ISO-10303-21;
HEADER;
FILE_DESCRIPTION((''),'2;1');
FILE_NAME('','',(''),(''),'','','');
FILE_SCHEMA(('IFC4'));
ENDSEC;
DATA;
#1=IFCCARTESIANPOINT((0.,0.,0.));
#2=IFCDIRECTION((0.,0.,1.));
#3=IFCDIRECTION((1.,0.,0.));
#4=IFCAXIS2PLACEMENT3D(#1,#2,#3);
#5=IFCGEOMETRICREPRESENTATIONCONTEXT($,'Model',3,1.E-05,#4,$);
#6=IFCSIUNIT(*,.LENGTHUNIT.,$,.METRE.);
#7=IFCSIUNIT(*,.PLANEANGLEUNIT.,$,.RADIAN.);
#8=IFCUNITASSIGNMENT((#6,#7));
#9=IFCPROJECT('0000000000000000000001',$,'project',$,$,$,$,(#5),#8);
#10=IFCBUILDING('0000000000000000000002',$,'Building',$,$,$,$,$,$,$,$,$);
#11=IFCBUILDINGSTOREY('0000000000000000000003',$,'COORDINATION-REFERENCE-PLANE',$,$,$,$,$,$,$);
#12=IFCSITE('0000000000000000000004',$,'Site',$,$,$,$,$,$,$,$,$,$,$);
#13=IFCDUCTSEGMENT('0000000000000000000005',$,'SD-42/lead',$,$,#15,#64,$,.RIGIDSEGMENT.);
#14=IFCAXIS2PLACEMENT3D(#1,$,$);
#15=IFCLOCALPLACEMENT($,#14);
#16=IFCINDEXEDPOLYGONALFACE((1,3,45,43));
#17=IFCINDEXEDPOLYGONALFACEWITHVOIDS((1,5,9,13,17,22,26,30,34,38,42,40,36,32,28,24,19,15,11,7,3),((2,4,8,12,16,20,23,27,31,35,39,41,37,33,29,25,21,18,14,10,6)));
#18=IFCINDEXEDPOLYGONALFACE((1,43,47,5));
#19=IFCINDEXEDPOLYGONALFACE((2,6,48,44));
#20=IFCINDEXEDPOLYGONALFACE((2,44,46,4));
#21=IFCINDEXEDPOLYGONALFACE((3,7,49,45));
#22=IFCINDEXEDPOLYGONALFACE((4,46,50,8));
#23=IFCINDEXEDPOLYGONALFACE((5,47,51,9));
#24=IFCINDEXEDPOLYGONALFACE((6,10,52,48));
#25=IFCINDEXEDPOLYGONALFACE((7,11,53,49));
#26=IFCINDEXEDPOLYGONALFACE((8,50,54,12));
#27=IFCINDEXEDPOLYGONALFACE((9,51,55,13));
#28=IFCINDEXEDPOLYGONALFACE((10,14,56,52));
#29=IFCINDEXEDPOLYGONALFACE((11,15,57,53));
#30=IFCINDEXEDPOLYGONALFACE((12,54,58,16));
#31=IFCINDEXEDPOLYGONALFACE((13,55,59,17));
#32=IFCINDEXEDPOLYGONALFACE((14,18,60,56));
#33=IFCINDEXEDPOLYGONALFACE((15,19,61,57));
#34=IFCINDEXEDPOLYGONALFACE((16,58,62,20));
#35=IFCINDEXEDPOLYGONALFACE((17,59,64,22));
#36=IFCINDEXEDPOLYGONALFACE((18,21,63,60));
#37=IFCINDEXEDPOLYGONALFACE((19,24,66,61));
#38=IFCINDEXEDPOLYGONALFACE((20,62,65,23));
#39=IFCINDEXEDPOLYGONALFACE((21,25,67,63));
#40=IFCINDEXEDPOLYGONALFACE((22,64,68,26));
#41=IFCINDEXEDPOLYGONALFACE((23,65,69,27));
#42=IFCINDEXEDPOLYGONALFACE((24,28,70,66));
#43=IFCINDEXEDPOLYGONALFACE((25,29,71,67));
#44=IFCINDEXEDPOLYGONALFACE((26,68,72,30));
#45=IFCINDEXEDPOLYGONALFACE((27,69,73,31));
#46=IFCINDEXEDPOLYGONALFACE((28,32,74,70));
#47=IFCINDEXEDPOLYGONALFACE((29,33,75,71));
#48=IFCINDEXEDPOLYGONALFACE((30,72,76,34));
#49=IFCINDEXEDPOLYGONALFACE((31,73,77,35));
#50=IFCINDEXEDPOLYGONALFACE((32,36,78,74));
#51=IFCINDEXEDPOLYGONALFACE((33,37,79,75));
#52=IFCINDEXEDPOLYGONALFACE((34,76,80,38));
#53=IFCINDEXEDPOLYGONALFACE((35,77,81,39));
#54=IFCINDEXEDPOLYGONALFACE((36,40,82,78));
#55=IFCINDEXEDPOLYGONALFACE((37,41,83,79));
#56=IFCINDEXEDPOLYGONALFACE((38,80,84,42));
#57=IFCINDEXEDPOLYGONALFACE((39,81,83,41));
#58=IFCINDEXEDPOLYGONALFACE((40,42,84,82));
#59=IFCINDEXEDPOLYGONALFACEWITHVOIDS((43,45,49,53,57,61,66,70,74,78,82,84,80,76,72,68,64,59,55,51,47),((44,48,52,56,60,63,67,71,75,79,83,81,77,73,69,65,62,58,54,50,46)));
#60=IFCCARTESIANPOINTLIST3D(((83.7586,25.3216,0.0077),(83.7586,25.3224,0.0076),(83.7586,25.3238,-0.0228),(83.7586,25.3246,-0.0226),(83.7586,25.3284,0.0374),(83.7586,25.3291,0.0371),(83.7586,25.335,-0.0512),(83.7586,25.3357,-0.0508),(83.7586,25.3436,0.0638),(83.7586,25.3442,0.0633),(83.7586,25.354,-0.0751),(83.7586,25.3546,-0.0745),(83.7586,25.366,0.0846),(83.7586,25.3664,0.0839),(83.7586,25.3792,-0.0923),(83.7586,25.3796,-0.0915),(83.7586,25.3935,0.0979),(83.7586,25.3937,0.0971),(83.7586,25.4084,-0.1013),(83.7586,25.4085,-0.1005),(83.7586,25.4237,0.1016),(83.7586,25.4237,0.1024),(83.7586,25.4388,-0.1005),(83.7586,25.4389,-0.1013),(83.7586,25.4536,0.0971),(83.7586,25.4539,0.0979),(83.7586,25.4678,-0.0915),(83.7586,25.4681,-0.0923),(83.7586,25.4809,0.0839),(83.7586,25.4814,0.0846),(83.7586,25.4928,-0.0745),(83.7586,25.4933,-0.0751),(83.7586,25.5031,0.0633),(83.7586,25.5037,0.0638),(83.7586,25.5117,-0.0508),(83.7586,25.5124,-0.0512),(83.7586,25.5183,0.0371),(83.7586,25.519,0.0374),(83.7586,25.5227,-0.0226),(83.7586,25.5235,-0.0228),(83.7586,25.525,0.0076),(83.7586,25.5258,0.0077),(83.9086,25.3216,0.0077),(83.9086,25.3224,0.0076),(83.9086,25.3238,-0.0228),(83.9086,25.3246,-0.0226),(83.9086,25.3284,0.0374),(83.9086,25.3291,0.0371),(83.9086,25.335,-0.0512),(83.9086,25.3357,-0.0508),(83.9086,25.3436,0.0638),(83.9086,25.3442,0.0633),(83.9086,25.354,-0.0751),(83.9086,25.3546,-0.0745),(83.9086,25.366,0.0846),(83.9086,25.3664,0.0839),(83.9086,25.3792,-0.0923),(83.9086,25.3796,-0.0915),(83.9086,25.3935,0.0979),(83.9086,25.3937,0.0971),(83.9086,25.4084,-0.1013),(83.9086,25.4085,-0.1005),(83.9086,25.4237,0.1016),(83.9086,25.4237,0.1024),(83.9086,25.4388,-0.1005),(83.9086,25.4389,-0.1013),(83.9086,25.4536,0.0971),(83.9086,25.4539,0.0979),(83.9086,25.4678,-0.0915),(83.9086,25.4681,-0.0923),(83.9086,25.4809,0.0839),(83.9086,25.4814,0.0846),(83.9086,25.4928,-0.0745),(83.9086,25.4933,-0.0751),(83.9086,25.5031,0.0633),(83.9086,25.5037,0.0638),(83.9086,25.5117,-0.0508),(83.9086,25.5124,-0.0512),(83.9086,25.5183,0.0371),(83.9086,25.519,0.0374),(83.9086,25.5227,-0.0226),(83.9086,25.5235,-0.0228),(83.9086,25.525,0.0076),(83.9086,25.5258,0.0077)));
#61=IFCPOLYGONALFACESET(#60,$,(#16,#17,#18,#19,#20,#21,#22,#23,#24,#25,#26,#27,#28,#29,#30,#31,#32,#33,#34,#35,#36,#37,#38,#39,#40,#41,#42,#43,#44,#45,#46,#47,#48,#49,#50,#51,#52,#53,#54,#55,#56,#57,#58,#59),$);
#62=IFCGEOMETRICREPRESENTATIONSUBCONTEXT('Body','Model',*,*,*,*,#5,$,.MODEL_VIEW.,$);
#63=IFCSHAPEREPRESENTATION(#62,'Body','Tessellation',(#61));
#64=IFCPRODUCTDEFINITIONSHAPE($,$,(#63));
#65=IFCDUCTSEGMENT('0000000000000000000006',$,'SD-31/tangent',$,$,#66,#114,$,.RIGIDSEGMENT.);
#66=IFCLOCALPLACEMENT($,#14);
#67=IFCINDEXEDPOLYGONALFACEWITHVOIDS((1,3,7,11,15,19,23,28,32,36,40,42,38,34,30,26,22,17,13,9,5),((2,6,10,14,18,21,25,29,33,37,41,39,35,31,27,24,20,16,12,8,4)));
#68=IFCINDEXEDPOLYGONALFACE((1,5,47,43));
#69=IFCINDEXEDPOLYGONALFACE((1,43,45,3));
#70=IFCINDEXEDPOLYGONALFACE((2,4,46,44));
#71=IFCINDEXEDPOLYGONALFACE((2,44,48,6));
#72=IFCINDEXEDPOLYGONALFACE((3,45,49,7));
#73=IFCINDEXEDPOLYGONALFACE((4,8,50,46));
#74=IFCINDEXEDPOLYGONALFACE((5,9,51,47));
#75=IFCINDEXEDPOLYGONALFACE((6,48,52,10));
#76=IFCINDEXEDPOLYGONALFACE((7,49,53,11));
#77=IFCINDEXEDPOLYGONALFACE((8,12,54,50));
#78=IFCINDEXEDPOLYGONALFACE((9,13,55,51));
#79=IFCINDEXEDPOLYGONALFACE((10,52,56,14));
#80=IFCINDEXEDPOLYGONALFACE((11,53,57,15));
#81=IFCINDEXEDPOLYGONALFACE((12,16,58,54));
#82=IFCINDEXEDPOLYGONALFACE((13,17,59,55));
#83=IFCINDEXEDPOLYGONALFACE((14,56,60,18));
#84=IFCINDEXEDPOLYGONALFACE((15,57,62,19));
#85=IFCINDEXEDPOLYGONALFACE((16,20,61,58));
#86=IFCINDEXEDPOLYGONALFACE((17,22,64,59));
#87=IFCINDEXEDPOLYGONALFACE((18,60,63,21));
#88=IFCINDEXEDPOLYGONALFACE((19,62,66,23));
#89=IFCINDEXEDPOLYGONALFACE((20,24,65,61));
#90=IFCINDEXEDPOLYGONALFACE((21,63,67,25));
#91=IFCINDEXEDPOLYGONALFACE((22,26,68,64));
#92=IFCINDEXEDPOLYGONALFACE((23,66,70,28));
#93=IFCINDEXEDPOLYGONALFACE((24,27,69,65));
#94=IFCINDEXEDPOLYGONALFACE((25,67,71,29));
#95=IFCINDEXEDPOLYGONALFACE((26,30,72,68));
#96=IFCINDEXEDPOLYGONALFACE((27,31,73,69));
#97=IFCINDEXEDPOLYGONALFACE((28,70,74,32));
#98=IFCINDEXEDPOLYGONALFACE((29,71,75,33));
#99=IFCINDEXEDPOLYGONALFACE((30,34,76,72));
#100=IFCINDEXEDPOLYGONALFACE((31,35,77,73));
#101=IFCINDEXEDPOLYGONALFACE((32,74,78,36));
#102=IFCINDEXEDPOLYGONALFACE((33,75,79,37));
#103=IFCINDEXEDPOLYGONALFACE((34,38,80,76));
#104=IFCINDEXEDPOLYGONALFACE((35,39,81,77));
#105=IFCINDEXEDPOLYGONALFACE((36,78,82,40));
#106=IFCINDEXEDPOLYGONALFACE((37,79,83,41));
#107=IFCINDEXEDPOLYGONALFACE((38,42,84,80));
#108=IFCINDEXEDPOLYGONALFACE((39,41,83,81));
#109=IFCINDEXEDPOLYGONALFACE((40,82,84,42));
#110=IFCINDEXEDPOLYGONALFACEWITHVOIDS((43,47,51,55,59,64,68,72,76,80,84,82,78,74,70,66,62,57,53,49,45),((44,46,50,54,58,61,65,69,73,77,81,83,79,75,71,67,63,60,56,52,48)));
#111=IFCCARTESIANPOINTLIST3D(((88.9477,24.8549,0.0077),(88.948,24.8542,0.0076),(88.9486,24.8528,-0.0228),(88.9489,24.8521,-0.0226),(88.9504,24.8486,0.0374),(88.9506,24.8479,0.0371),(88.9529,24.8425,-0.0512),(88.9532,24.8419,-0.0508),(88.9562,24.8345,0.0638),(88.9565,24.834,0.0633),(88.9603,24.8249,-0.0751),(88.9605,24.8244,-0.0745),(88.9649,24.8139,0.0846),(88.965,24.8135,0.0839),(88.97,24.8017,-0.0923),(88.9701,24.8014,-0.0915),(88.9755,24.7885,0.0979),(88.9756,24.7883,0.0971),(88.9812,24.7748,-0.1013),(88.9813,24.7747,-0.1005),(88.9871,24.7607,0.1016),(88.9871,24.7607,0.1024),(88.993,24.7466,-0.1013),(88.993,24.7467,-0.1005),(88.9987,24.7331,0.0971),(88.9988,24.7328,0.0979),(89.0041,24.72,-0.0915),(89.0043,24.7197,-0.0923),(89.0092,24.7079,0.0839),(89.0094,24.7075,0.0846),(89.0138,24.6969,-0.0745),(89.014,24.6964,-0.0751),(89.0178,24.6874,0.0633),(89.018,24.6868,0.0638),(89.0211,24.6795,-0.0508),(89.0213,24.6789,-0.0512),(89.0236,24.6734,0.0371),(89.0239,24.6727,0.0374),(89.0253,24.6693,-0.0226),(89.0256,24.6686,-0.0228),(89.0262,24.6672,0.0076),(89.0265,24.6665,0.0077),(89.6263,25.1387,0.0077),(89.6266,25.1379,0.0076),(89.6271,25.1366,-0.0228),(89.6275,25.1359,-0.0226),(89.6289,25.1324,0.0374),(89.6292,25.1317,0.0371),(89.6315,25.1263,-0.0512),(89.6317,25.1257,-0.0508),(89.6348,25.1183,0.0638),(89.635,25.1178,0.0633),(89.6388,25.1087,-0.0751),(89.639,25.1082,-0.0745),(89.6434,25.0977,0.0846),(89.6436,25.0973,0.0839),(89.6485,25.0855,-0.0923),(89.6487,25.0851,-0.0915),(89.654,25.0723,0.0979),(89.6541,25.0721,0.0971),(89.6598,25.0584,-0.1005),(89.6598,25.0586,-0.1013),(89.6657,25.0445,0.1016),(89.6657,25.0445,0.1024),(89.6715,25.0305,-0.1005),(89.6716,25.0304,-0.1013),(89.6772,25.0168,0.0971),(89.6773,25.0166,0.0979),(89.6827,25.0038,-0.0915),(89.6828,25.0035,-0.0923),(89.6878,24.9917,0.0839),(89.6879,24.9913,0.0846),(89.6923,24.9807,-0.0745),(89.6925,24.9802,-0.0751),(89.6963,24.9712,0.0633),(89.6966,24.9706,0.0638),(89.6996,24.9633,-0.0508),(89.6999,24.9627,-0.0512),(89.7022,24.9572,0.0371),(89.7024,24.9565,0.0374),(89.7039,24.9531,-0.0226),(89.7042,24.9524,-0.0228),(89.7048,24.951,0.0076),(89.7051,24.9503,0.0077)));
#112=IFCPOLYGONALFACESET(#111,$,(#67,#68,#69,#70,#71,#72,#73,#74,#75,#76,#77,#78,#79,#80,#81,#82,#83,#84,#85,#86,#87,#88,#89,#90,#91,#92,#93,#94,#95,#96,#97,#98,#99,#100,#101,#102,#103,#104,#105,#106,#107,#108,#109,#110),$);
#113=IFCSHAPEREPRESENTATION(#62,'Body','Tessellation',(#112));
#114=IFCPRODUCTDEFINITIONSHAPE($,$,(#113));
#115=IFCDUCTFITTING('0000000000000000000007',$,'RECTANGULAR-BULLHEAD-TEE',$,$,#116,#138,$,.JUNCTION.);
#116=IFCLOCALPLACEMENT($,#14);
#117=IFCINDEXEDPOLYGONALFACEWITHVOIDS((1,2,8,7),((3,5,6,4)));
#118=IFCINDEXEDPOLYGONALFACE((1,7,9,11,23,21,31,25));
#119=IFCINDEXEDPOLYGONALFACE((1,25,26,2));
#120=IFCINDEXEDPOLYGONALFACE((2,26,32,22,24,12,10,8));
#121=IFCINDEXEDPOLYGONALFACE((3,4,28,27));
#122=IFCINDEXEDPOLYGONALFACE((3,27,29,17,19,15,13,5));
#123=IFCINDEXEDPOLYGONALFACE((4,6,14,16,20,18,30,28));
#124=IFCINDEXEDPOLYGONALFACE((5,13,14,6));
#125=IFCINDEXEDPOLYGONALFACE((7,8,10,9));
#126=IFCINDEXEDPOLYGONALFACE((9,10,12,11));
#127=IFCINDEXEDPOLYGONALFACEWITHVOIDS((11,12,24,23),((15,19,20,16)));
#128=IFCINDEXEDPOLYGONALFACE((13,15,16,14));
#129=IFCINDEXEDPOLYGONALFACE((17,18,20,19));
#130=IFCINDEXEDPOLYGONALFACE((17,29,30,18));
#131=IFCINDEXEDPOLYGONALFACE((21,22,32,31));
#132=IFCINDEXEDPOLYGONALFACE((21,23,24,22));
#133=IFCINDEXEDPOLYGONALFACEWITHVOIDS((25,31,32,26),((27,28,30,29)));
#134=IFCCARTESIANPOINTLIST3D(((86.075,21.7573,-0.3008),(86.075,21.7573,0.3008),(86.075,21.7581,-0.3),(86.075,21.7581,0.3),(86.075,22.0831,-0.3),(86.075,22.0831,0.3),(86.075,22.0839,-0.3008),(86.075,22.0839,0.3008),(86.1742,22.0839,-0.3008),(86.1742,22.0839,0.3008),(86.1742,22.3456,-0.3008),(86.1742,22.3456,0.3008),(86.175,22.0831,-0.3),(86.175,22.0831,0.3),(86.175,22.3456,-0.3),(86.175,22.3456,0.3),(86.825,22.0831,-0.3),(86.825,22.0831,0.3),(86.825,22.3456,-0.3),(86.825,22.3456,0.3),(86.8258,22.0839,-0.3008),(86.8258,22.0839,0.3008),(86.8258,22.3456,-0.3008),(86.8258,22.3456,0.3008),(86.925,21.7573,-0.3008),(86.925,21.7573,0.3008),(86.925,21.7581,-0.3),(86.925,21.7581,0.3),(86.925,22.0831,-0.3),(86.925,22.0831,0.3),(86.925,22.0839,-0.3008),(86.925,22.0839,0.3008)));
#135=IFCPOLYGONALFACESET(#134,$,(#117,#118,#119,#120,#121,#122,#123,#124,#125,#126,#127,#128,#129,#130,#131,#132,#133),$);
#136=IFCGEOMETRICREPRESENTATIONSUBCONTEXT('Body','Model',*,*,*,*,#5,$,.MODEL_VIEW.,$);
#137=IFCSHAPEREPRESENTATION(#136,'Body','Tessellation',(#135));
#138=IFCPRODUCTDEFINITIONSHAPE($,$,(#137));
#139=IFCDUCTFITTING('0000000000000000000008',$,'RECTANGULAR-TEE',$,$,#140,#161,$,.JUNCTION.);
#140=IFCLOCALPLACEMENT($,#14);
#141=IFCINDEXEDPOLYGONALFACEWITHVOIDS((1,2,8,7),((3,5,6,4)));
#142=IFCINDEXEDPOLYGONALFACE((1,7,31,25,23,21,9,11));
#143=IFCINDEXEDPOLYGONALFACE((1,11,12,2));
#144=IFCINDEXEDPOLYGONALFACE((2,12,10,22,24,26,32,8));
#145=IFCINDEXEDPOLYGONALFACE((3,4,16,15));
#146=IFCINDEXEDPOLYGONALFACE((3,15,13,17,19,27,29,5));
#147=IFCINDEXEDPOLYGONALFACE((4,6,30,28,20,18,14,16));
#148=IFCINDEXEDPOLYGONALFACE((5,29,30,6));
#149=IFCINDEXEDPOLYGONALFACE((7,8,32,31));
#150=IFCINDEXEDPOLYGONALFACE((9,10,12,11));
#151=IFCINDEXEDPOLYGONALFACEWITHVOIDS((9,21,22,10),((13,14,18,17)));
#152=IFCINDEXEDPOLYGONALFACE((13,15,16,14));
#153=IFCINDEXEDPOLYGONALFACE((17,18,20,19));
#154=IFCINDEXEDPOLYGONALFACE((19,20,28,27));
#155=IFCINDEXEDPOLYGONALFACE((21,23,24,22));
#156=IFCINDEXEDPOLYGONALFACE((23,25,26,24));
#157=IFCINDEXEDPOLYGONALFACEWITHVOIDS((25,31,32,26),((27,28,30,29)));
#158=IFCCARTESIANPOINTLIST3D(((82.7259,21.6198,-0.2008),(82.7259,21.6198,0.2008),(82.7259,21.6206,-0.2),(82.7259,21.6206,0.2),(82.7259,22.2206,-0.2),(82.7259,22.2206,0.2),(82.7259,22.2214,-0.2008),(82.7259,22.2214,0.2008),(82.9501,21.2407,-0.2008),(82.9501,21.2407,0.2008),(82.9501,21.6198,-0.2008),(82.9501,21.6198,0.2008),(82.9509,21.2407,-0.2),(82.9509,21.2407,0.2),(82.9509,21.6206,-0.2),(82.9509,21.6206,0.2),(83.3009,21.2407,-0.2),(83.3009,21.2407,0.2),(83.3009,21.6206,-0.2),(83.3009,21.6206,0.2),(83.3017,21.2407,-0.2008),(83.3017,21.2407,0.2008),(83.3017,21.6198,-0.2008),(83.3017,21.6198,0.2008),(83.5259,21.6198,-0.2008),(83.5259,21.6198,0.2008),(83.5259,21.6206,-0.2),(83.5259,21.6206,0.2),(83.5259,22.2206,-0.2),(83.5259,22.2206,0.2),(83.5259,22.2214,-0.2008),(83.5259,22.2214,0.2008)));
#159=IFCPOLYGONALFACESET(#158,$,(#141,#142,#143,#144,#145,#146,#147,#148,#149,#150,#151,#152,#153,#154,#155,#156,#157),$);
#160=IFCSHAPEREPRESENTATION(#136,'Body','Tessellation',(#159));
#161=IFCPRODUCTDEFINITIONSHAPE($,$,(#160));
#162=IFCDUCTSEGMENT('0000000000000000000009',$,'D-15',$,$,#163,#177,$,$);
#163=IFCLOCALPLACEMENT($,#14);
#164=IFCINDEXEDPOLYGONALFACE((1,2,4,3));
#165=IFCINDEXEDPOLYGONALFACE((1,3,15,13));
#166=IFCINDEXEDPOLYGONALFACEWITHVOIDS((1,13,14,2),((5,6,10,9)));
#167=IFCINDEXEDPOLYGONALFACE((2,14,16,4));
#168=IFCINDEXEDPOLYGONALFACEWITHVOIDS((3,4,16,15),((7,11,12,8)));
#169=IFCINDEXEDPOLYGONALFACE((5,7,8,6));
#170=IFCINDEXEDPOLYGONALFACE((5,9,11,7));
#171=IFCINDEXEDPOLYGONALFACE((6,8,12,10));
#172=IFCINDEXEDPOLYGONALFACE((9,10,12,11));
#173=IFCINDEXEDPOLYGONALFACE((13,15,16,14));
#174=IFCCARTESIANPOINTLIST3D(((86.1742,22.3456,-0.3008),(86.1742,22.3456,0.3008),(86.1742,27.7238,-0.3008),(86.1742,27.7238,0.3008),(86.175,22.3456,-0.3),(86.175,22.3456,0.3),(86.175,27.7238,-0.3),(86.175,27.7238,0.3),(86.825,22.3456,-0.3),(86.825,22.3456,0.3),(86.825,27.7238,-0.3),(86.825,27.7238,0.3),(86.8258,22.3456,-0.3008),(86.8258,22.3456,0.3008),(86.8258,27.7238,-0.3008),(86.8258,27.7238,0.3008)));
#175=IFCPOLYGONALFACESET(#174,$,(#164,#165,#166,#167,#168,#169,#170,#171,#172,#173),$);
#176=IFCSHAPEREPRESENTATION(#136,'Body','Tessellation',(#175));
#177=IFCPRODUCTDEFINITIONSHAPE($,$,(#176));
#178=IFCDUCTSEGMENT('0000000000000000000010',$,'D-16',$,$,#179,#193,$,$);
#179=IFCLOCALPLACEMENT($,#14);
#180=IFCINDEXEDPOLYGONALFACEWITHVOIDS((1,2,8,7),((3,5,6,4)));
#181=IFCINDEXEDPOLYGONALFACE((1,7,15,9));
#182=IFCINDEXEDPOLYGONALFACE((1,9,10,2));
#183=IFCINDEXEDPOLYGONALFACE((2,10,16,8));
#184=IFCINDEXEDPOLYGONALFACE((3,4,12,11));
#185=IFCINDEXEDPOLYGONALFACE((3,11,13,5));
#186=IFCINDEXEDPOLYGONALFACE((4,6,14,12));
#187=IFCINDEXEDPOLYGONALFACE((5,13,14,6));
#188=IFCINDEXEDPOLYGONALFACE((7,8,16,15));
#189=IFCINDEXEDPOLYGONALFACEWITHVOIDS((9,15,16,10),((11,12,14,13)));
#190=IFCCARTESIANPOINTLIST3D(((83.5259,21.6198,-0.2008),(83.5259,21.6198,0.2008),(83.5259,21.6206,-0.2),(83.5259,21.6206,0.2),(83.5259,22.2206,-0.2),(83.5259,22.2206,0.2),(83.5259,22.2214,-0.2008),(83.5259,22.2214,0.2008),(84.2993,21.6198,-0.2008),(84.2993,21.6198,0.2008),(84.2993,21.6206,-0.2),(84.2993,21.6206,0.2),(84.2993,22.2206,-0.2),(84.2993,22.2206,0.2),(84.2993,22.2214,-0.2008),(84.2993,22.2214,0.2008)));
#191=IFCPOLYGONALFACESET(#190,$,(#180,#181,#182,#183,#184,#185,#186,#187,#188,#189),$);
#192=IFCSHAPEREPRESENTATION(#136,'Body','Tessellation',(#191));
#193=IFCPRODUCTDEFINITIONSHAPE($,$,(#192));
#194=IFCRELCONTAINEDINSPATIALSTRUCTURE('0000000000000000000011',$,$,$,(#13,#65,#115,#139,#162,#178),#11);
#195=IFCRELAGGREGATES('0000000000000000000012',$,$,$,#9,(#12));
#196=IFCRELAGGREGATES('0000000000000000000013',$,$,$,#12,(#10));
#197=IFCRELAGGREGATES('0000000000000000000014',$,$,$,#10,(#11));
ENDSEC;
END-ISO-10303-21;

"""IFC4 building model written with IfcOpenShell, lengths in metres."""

from ifc_helpers import new_model, si_unit, frame, origin, origin_with_axes, place, context, subcontext, project, spatial, rectangle, hollow_rectangle, hollow_circle, extrude, boolean, element, save


model = new_model("IFC4")

# Units and contexts
model_context = context("Model", 3, precision=1e-05, world=origin_with_axes())
body_context_1 = subcontext(model_context, "Body", "Model", "MODEL_VIEW")
body_context_2 = subcontext(model_context, "Body", "Model", "MODEL_VIEW")
ifc_project = project(units=[si_unit("LENGTHUNIT", "METRE"), si_unit("PLANEANGLEUNIT", "RADIAN")], contexts=[model_context])

# Site, building, storey
site = spatial("IfcSite", under=ifc_project, Name="Site")
building = spatial("IfcBuilding", under=site, Name="Building")
storey = spatial("IfcBuildingStorey", under=building, Name="COORDINATION-REFERENCE-PLANE")

# Duct segment
duct_segment_1_placement = place(None, frame((83.7586, 25.4237, 0.0), z_axis=(1.0, 0.0, 0.0), x_axis=(0.0, 0.0, 1.0)))
element("IfcDuctSegment", 1, at=duct_segment_1_placement, inside=storey, Name="SD-42/lead", PredefinedType="RIGIDSEGMENT", context=body_context_1, shape_type="SweptSolid", body=[
    extrude(hollow_circle(Radius=0.1024, WallThickness=0.0008), origin_with_axes(), (0.0, 0.0, 1.0), 0.15),
])

# Duct segment
duct_segment_2_placement = place(None, frame((89.6657, 25.0445, 0.0), z_axis=(-0.922564, -0.385845, 0.0), x_axis=(0.0, 0.0, 1.0)))
element("IfcDuctSegment", 2, at=duct_segment_2_placement, inside=storey, Name="SD-31/tangent", PredefinedType="RIGIDSEGMENT", context=body_context_1, shape_type="SweptSolid", body=[
    extrude(hollow_circle(Radius=0.1024, WallThickness=0.0008), origin_with_axes(), (0.0, 0.0, 1.0), 0.7355),
])

# Duct fittings
duct_fitting_1_placement = place(None, frame((86.5, 21.9206, 0.0), z_axis=(1.0, 0.0, 0.0), x_axis=(0.0, 1.0, 0.0)))
solid_1 = boolean("UNION", extrude(rectangle(XDim=0.325, YDim=0.6), frame((0.0, 0.0, -0.425), z_axis=(0.0, 0.0, 1.0), x_axis=(1.0, 0.0, 0.0)), (0.0, 0.0, 1.0), 0.85), extrude(rectangle(XDim=0.65, YDim=0.6), frame((0.0, 0.0, 0.0), z_axis=(1.0, 0.0, 0.0), x_axis=(0.0, 0.0, -1.0)), (0.0, 0.0, 1.0), 0.425))
element("IfcDuctFitting", 3, at=duct_fitting_1_placement, inside=storey, Name="RECTANGULAR-BULLHEAD-TEE", PredefinedType="JUNCTION", context=body_context_2, shape_type="CSG", body=[
    boolean("DIFFERENCE", boolean("UNION", extrude(rectangle(XDim=0.3266, YDim=0.6016), frame((0.0, 0.0, -0.425), z_axis=(0.0, 0.0, 1.0), x_axis=(1.0, 0.0, 0.0)), (0.0, 0.0, 1.0), 0.85), extrude(rectangle(XDim=0.6516, YDim=0.6016), frame((0.0, 0.0, 0.0), z_axis=(1.0, 0.0, 0.0), x_axis=(0.0, 0.0, -1.0)), (0.0, 0.0, 1.0), 0.425)), solid_1),
])
duct_fitting_2_placement = place(None, frame((83.1259, 21.9206, 0.0), z_axis=(-1.0, 0.0, 0.0), x_axis=(0.0, -1.0, 0.0)))
solid_2 = boolean("UNION", extrude(rectangle(XDim=0.6, YDim=0.4), frame((0.0, 0.0, -0.4), z_axis=(0.0, 0.0, 1.0), x_axis=(1.0, 0.0, 0.0)), (0.0, 0.0, 1.0), 0.8), extrude(rectangle(XDim=0.35, YDim=0.4), frame((0.0, 0.0, 0.0), z_axis=(1.0, 0.0, 0.0), x_axis=(0.0, 0.0, -1.0)), (0.0, 0.0, 1.0), 0.6799))
element("IfcDuctFitting", 4, at=duct_fitting_2_placement, inside=storey, Name="RECTANGULAR-TEE", PredefinedType="JUNCTION", context=body_context_2, shape_type="CSG", body=[
    boolean("DIFFERENCE", boolean("UNION", extrude(rectangle(XDim=0.6016, YDim=0.4016), frame((0.0, 0.0, -0.4), z_axis=(0.0, 0.0, 1.0), x_axis=(1.0, 0.0, 0.0)), (0.0, 0.0, 1.0), 0.8), extrude(rectangle(XDim=0.3516, YDim=0.4016), frame((0.0, 0.0, 0.0), z_axis=(1.0, 0.0, 0.0), x_axis=(0.0, 0.0, -1.0)), (0.0, 0.0, 1.0), 0.6799)), solid_2),
])

# Duct segments
duct_segment_3_placement = place(None, frame((86.5, 22.3456, 0.0), z_axis=(0.0, 1.0, 0.0), x_axis=(1.0, 0.0, 0.0)))
element("IfcDuctSegment", 5, at=duct_segment_3_placement, inside=storey, Name="D-15", context=body_context_2, shape_type="SweptSolid", body=[
    extrude(hollow_rectangle(XDim=0.6516, YDim=0.6016, WallThickness=0.0008), origin(), (0.0, 0.0, 1.0), 5.3782),
])
duct_segment_4_placement = place(None, frame((83.5259, 21.9206, 0.0), z_axis=(1.0, 0.0, 0.0), x_axis=(0.0, 1.0, 0.0)))
element("IfcDuctSegment", 6, at=duct_segment_4_placement, inside=storey, Name="D-16", context=body_context_2, shape_type="SweptSolid", body=[
    extrude(hollow_rectangle(XDim=0.6016, YDim=0.4016, WallThickness=0.0008), origin(), (0.0, 0.0, 1.0), 0.7733),
])

save(model, "model.ifc")
